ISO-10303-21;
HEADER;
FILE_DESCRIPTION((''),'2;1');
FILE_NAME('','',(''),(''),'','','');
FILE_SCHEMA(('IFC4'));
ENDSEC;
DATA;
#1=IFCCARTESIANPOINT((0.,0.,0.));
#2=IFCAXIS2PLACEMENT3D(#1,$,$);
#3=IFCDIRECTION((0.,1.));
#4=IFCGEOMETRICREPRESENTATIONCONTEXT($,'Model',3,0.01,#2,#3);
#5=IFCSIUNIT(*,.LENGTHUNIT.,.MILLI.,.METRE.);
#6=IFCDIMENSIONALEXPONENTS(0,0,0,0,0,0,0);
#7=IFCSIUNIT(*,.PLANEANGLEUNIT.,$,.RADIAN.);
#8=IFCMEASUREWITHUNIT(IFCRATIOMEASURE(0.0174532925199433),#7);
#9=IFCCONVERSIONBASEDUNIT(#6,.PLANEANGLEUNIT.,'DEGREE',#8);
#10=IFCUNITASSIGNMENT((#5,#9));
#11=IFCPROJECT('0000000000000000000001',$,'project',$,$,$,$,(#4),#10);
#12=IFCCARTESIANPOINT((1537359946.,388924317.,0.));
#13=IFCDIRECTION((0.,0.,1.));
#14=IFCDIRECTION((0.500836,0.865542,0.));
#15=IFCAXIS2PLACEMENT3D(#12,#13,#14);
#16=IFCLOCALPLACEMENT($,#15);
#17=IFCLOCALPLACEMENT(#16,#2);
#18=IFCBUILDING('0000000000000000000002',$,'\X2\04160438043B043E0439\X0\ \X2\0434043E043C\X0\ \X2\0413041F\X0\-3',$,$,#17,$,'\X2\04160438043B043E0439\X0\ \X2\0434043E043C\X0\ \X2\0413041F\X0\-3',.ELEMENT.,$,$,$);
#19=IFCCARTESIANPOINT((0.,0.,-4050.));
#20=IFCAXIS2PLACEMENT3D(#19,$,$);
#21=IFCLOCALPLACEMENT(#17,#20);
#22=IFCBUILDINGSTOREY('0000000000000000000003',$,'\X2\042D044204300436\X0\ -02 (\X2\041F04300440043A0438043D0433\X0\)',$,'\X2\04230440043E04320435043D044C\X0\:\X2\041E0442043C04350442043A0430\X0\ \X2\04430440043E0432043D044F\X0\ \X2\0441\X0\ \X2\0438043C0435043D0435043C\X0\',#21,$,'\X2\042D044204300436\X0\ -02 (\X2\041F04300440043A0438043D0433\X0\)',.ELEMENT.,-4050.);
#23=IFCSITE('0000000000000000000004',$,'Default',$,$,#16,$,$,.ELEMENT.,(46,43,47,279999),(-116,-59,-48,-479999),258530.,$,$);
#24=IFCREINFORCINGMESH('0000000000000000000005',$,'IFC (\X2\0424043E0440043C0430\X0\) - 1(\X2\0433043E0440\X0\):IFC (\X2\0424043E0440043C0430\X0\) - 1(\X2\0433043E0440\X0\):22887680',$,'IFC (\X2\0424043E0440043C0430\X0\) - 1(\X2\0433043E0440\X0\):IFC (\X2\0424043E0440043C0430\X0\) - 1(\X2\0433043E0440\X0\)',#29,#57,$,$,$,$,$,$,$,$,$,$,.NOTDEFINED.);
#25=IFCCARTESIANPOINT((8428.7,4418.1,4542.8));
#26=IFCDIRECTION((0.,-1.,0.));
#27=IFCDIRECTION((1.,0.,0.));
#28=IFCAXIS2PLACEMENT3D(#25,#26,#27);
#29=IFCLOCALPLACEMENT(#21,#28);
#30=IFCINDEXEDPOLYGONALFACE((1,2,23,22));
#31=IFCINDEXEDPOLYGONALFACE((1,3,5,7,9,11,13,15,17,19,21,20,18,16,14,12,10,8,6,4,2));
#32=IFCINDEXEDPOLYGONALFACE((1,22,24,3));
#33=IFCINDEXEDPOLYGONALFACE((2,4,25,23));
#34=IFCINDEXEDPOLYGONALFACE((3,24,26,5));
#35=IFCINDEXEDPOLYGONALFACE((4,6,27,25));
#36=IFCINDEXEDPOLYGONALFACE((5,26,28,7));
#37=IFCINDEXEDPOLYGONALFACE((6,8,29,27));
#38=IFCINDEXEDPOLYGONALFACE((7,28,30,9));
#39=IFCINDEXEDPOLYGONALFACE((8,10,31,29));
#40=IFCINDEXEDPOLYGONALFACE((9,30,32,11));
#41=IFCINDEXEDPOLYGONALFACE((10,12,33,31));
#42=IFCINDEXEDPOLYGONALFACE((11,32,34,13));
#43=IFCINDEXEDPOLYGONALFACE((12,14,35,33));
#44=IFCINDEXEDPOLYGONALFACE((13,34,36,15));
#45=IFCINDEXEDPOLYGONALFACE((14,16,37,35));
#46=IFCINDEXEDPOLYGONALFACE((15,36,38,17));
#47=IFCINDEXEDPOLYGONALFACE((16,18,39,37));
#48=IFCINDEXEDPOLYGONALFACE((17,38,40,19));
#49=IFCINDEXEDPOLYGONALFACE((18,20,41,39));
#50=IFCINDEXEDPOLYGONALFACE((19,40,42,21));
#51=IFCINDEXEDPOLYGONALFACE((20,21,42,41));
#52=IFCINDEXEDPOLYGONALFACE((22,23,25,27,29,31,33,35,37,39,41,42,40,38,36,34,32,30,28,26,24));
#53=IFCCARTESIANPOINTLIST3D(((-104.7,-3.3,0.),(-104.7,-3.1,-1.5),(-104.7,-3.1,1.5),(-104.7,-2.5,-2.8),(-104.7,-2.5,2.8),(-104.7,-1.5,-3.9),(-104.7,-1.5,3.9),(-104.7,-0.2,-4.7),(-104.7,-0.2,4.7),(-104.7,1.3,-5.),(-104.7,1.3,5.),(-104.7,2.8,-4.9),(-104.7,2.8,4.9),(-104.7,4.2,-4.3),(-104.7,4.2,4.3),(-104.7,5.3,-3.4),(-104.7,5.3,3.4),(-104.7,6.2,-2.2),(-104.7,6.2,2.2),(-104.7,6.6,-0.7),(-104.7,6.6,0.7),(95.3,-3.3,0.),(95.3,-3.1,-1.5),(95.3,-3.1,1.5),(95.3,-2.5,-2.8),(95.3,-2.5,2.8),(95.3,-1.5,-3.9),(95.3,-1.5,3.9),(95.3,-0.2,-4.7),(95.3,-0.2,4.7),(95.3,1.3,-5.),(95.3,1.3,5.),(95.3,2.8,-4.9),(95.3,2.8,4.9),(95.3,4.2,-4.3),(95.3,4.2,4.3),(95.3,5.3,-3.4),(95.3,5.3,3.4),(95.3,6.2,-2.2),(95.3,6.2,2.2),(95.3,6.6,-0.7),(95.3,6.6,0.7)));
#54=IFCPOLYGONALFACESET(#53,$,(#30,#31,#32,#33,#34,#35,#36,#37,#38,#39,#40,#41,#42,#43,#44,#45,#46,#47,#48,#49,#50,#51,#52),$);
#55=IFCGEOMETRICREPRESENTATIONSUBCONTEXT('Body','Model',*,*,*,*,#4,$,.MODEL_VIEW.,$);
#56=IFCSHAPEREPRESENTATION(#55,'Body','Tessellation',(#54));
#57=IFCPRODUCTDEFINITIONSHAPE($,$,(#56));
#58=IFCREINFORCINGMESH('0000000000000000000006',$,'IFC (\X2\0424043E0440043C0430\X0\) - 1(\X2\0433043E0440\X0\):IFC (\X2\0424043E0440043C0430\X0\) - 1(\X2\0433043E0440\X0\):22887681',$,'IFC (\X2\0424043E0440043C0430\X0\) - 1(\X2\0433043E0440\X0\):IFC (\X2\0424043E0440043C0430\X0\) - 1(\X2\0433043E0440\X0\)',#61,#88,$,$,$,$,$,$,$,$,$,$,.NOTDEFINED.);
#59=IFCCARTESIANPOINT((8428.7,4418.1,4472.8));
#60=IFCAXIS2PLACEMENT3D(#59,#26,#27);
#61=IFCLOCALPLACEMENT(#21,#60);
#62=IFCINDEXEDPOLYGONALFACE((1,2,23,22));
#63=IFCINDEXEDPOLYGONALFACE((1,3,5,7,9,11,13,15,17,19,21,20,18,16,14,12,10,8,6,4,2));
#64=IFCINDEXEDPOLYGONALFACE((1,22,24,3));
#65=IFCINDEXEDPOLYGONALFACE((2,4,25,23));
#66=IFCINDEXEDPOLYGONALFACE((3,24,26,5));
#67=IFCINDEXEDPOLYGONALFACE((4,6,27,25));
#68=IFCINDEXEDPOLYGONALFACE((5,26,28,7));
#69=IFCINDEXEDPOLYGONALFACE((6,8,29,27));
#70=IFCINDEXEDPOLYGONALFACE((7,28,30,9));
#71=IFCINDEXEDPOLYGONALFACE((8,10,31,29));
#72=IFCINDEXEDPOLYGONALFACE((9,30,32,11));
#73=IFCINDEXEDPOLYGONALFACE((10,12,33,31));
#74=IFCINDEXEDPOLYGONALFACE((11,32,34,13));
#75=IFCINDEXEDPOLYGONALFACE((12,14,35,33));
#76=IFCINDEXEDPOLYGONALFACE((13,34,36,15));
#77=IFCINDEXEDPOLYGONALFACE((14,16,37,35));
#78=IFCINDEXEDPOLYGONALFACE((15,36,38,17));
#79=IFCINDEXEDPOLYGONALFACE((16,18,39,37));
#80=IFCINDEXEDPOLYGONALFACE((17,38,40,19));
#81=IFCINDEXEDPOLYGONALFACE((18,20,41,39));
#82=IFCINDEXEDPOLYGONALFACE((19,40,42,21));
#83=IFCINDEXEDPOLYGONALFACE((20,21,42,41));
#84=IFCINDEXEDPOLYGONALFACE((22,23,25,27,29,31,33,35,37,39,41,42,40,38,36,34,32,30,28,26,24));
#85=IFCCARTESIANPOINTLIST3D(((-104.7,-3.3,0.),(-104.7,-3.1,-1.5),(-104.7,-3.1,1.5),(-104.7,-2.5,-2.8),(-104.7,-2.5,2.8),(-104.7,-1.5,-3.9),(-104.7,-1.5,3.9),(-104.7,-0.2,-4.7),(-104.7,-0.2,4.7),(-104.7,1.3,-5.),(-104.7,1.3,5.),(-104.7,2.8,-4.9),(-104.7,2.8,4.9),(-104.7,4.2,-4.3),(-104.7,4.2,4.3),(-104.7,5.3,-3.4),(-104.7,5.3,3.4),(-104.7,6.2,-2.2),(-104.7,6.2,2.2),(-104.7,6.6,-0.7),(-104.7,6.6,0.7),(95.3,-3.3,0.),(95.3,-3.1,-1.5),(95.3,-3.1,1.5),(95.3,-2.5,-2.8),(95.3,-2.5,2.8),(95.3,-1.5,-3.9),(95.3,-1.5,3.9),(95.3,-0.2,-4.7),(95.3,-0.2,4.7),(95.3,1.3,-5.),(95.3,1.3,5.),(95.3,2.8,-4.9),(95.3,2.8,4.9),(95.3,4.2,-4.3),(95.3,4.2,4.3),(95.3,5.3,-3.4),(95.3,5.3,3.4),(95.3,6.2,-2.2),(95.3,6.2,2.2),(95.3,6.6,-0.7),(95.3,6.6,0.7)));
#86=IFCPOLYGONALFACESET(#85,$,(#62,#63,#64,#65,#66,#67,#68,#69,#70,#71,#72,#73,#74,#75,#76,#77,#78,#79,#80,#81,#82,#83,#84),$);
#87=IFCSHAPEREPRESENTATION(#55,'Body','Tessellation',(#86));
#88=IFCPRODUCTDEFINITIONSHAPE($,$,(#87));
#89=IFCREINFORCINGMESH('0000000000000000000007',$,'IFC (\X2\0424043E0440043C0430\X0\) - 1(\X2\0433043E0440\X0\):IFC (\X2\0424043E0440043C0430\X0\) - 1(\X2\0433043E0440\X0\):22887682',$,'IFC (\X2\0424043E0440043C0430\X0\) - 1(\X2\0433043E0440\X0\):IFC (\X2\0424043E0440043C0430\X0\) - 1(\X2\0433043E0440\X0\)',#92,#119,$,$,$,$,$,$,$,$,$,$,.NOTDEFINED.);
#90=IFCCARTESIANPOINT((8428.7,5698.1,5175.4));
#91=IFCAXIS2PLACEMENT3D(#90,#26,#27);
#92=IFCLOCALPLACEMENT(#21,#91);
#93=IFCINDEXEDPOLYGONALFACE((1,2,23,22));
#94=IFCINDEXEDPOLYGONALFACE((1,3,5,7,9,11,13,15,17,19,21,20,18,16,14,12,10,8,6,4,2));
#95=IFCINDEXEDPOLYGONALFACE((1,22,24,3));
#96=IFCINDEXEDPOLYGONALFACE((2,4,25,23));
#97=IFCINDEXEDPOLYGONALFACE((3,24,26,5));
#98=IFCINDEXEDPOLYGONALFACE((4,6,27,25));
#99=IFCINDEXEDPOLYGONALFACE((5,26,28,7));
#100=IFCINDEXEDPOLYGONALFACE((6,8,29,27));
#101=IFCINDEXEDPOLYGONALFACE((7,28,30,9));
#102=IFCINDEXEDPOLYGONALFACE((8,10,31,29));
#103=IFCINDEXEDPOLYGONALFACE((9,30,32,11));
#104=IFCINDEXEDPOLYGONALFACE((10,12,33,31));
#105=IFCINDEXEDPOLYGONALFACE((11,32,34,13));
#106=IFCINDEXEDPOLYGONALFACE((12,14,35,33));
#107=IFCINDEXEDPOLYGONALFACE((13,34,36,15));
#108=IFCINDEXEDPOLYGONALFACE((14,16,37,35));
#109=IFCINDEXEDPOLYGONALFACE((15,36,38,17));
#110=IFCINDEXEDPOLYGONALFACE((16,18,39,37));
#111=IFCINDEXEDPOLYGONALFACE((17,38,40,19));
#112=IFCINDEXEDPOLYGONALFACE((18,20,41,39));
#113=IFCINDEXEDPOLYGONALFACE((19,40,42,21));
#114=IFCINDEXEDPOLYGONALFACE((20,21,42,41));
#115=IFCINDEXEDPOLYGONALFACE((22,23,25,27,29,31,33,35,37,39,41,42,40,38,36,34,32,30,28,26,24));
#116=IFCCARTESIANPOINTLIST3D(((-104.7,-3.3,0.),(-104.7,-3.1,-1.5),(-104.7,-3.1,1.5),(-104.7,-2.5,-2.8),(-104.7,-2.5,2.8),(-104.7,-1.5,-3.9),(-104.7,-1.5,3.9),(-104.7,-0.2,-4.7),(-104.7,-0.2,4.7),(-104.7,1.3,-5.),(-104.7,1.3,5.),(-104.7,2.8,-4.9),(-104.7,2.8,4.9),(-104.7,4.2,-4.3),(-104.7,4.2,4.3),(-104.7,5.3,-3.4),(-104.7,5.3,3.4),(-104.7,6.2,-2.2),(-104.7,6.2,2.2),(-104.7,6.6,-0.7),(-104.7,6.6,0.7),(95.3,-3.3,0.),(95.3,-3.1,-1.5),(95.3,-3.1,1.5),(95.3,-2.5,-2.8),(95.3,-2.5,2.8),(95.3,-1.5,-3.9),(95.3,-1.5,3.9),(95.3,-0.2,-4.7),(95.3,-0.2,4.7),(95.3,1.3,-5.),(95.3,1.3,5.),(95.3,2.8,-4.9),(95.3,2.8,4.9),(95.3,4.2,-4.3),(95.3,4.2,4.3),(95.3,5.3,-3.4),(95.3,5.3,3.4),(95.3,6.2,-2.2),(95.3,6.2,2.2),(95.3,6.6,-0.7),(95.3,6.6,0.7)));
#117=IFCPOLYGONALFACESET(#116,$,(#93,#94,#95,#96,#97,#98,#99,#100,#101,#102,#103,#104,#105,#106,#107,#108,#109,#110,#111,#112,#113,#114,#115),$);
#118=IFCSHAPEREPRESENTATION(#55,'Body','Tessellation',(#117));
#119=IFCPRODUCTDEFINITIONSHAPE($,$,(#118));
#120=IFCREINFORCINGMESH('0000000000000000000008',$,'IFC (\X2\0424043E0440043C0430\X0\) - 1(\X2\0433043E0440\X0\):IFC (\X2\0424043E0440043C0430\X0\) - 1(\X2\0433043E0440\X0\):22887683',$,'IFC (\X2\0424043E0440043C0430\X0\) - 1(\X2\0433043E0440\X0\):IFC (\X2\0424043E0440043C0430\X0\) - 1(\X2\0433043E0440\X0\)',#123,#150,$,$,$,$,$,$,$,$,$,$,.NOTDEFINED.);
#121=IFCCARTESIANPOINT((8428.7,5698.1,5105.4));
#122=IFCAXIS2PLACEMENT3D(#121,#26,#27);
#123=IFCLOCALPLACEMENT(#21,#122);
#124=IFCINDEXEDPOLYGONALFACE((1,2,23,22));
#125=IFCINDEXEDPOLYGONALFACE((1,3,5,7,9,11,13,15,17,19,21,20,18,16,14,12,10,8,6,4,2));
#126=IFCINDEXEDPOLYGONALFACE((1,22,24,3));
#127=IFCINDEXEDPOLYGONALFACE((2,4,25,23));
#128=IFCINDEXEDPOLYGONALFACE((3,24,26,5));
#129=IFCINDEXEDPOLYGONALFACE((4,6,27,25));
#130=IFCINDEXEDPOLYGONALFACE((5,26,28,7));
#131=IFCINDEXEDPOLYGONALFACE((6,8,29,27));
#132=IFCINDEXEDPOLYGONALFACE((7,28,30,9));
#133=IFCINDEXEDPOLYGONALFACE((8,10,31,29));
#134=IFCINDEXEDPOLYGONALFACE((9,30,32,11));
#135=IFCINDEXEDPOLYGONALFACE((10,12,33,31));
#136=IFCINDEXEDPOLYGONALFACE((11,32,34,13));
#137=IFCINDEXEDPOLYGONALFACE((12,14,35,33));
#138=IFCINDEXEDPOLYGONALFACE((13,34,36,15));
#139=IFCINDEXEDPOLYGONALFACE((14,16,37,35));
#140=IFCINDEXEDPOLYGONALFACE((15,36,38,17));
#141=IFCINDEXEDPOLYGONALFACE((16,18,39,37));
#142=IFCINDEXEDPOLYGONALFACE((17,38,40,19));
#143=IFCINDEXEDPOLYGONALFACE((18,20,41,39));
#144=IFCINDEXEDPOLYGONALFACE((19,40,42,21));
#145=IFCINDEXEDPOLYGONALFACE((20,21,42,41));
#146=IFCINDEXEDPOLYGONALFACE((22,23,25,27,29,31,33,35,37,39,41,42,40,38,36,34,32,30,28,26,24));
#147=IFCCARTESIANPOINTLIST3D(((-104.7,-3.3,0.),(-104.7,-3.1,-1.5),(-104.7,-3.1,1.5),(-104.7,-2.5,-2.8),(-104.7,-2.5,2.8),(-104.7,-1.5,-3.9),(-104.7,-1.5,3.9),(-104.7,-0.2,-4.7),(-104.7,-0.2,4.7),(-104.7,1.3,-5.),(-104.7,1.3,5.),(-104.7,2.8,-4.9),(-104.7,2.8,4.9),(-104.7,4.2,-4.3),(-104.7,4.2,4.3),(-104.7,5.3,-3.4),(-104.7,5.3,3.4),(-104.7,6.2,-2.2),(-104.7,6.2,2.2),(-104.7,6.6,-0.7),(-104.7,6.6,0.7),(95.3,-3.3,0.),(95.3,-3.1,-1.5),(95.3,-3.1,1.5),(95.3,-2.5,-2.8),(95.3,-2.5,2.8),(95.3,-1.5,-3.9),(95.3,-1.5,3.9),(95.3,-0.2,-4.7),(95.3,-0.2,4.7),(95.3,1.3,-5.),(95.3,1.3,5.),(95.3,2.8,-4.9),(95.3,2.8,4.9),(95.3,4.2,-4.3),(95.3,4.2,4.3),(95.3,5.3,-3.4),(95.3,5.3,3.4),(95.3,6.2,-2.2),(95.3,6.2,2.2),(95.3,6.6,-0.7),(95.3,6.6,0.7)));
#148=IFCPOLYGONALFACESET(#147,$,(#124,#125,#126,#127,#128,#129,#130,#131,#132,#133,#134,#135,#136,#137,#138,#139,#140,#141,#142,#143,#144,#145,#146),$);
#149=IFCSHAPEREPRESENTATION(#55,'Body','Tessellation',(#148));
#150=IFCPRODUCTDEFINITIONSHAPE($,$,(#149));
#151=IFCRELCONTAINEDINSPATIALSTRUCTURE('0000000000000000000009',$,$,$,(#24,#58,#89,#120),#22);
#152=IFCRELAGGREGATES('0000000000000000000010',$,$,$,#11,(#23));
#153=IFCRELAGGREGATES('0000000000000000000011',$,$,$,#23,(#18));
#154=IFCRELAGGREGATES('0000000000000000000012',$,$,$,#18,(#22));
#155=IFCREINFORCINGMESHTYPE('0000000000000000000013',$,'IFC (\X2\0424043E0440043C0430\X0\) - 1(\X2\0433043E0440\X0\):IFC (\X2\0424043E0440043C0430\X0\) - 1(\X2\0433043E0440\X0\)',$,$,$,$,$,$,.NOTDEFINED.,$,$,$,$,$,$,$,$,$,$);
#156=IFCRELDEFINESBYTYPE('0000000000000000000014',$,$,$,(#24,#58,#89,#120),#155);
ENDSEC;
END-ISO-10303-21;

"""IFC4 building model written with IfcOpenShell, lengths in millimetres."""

from ifc_helpers import new_model, entity, si_unit, converted_unit, direction, frame, frame_2d, origin, place, context, subcontext, project, spatial, circle, extrude, source, transform, mapped, type_object, type_shapes, element, save


model = new_model("IFC4")

# Units and contexts
model_context = context("Model", 3, precision=0.01, world=origin(), true_north=direction((0.0, 1.0)))
body_context = subcontext(model_context, "Body", "Model", "MODEL_VIEW")
ifc_project = project(units=[si_unit("LENGTHUNIT", "METRE", prefix="MILLI"), converted_unit("PLANEANGLEUNIT", "DEGREE", entity("IfcRatioMeasure", 0.0174532925199433), si_unit("PLANEANGLEUNIT", "RADIAN"), dimensions=[0, 0, 0, 0, 0, 0, 0])], contexts=[model_context])

# Site, building, storey
site_placement = place(None, frame((1537359946.0, 388924317.0, 0.0), z_axis=(0.0, 0.0, 1.0), x_axis=(0.500836, 0.865542, 0.0)))
site = spatial("IfcSite", under=ifc_project, at=site_placement, Name="Default", CompositionType="ELEMENT", RefLatitude=(46, 43, 47, 279999), RefLongitude=(-116, -59, -48, -479999), RefElevation=258530.0)
building_placement = place(site_placement, origin())
building = spatial("IfcBuilding", under=site, at=building_placement, Name="Жилой дом ГП-3", LongName="Жилой дом ГП-3", CompositionType="ELEMENT")
storey_placement = place(building_placement, frame((0.0, 0.0, -4050.0)))
storey = spatial("IfcBuildingStorey", under=building, at=storey_placement, Name="Этаж -02 (Паркинг)", ObjectType="Уровень:Отметка уровня с именем", LongName="Этаж -02 (Паркинг)", CompositionType="ELEMENT", Elevation=-4050.0)

# Reinforcing meshes
reinforcing_mesh_type = type_object("IfcReinforcingMeshType", Name="IFC (Форма) - 1(гор):IFC (Форма) - 1(гор)", PredefinedType="NOTDEFINED")
shared_shape_1 = source(origin(), body_context, "Body", "SweptSolid", [
    extrude(circle(Radius=5.0, at=frame_2d((0.0, 0.0), x_axis=(1.0, 0.0))), frame((-104.7, 1.7, 0.0), z_axis=(1.0, 0.0, 0.0), x_axis=(0.0, -1.0, 0.0)), (0.0, 0.0, 1.0), 200.0),
])
type_shapes(reinforcing_mesh_type, [shared_shape_1])
for number, where, z_axis, x_axis, name in (
    (1, (8428.7, 4418.1, 4542.8), (0.0, -1.0, 0.0), (1.0, 0.0, 0.0), "IFC (Форма) - 1(гор):IFC (Форма) - 1(гор):22887680"),
    (2, (8428.7, 4418.1, 4472.8), (0.0, -1.0, 0.0), (1.0, 0.0, 0.0), "IFC (Форма) - 1(гор):IFC (Форма) - 1(гор):22887681"),
    (3, (8428.7, 5698.1, 5175.4), (0.0, -1.0, 0.0), (1.0, 0.0, 0.0), "IFC (Форма) - 1(гор):IFC (Форма) - 1(гор):22887682"),
    (4, (8428.7, 5698.1, 5105.4), (0.0, -1.0, 0.0), (1.0, 0.0, 0.0), "IFC (Форма) - 1(гор):IFC (Форма) - 1(гор):22887683"),
):
    element("IfcReinforcingMesh", number, at=place(storey_placement, frame(where, z_axis=z_axis, x_axis=x_axis)), inside=storey, type_object=reinforcing_mesh_type, Name=name, ObjectType="IFC (Форма) - 1(гор):IFC (Форма) - 1(гор)", PredefinedType="NOTDEFINED", context=body_context, shape_type="MappedRepresentation", body=[
        mapped(shared_shape_1, transform((0.0, 0.0, 0.0), scale=1.0)),
    ])

save(model, "model.ifc")
